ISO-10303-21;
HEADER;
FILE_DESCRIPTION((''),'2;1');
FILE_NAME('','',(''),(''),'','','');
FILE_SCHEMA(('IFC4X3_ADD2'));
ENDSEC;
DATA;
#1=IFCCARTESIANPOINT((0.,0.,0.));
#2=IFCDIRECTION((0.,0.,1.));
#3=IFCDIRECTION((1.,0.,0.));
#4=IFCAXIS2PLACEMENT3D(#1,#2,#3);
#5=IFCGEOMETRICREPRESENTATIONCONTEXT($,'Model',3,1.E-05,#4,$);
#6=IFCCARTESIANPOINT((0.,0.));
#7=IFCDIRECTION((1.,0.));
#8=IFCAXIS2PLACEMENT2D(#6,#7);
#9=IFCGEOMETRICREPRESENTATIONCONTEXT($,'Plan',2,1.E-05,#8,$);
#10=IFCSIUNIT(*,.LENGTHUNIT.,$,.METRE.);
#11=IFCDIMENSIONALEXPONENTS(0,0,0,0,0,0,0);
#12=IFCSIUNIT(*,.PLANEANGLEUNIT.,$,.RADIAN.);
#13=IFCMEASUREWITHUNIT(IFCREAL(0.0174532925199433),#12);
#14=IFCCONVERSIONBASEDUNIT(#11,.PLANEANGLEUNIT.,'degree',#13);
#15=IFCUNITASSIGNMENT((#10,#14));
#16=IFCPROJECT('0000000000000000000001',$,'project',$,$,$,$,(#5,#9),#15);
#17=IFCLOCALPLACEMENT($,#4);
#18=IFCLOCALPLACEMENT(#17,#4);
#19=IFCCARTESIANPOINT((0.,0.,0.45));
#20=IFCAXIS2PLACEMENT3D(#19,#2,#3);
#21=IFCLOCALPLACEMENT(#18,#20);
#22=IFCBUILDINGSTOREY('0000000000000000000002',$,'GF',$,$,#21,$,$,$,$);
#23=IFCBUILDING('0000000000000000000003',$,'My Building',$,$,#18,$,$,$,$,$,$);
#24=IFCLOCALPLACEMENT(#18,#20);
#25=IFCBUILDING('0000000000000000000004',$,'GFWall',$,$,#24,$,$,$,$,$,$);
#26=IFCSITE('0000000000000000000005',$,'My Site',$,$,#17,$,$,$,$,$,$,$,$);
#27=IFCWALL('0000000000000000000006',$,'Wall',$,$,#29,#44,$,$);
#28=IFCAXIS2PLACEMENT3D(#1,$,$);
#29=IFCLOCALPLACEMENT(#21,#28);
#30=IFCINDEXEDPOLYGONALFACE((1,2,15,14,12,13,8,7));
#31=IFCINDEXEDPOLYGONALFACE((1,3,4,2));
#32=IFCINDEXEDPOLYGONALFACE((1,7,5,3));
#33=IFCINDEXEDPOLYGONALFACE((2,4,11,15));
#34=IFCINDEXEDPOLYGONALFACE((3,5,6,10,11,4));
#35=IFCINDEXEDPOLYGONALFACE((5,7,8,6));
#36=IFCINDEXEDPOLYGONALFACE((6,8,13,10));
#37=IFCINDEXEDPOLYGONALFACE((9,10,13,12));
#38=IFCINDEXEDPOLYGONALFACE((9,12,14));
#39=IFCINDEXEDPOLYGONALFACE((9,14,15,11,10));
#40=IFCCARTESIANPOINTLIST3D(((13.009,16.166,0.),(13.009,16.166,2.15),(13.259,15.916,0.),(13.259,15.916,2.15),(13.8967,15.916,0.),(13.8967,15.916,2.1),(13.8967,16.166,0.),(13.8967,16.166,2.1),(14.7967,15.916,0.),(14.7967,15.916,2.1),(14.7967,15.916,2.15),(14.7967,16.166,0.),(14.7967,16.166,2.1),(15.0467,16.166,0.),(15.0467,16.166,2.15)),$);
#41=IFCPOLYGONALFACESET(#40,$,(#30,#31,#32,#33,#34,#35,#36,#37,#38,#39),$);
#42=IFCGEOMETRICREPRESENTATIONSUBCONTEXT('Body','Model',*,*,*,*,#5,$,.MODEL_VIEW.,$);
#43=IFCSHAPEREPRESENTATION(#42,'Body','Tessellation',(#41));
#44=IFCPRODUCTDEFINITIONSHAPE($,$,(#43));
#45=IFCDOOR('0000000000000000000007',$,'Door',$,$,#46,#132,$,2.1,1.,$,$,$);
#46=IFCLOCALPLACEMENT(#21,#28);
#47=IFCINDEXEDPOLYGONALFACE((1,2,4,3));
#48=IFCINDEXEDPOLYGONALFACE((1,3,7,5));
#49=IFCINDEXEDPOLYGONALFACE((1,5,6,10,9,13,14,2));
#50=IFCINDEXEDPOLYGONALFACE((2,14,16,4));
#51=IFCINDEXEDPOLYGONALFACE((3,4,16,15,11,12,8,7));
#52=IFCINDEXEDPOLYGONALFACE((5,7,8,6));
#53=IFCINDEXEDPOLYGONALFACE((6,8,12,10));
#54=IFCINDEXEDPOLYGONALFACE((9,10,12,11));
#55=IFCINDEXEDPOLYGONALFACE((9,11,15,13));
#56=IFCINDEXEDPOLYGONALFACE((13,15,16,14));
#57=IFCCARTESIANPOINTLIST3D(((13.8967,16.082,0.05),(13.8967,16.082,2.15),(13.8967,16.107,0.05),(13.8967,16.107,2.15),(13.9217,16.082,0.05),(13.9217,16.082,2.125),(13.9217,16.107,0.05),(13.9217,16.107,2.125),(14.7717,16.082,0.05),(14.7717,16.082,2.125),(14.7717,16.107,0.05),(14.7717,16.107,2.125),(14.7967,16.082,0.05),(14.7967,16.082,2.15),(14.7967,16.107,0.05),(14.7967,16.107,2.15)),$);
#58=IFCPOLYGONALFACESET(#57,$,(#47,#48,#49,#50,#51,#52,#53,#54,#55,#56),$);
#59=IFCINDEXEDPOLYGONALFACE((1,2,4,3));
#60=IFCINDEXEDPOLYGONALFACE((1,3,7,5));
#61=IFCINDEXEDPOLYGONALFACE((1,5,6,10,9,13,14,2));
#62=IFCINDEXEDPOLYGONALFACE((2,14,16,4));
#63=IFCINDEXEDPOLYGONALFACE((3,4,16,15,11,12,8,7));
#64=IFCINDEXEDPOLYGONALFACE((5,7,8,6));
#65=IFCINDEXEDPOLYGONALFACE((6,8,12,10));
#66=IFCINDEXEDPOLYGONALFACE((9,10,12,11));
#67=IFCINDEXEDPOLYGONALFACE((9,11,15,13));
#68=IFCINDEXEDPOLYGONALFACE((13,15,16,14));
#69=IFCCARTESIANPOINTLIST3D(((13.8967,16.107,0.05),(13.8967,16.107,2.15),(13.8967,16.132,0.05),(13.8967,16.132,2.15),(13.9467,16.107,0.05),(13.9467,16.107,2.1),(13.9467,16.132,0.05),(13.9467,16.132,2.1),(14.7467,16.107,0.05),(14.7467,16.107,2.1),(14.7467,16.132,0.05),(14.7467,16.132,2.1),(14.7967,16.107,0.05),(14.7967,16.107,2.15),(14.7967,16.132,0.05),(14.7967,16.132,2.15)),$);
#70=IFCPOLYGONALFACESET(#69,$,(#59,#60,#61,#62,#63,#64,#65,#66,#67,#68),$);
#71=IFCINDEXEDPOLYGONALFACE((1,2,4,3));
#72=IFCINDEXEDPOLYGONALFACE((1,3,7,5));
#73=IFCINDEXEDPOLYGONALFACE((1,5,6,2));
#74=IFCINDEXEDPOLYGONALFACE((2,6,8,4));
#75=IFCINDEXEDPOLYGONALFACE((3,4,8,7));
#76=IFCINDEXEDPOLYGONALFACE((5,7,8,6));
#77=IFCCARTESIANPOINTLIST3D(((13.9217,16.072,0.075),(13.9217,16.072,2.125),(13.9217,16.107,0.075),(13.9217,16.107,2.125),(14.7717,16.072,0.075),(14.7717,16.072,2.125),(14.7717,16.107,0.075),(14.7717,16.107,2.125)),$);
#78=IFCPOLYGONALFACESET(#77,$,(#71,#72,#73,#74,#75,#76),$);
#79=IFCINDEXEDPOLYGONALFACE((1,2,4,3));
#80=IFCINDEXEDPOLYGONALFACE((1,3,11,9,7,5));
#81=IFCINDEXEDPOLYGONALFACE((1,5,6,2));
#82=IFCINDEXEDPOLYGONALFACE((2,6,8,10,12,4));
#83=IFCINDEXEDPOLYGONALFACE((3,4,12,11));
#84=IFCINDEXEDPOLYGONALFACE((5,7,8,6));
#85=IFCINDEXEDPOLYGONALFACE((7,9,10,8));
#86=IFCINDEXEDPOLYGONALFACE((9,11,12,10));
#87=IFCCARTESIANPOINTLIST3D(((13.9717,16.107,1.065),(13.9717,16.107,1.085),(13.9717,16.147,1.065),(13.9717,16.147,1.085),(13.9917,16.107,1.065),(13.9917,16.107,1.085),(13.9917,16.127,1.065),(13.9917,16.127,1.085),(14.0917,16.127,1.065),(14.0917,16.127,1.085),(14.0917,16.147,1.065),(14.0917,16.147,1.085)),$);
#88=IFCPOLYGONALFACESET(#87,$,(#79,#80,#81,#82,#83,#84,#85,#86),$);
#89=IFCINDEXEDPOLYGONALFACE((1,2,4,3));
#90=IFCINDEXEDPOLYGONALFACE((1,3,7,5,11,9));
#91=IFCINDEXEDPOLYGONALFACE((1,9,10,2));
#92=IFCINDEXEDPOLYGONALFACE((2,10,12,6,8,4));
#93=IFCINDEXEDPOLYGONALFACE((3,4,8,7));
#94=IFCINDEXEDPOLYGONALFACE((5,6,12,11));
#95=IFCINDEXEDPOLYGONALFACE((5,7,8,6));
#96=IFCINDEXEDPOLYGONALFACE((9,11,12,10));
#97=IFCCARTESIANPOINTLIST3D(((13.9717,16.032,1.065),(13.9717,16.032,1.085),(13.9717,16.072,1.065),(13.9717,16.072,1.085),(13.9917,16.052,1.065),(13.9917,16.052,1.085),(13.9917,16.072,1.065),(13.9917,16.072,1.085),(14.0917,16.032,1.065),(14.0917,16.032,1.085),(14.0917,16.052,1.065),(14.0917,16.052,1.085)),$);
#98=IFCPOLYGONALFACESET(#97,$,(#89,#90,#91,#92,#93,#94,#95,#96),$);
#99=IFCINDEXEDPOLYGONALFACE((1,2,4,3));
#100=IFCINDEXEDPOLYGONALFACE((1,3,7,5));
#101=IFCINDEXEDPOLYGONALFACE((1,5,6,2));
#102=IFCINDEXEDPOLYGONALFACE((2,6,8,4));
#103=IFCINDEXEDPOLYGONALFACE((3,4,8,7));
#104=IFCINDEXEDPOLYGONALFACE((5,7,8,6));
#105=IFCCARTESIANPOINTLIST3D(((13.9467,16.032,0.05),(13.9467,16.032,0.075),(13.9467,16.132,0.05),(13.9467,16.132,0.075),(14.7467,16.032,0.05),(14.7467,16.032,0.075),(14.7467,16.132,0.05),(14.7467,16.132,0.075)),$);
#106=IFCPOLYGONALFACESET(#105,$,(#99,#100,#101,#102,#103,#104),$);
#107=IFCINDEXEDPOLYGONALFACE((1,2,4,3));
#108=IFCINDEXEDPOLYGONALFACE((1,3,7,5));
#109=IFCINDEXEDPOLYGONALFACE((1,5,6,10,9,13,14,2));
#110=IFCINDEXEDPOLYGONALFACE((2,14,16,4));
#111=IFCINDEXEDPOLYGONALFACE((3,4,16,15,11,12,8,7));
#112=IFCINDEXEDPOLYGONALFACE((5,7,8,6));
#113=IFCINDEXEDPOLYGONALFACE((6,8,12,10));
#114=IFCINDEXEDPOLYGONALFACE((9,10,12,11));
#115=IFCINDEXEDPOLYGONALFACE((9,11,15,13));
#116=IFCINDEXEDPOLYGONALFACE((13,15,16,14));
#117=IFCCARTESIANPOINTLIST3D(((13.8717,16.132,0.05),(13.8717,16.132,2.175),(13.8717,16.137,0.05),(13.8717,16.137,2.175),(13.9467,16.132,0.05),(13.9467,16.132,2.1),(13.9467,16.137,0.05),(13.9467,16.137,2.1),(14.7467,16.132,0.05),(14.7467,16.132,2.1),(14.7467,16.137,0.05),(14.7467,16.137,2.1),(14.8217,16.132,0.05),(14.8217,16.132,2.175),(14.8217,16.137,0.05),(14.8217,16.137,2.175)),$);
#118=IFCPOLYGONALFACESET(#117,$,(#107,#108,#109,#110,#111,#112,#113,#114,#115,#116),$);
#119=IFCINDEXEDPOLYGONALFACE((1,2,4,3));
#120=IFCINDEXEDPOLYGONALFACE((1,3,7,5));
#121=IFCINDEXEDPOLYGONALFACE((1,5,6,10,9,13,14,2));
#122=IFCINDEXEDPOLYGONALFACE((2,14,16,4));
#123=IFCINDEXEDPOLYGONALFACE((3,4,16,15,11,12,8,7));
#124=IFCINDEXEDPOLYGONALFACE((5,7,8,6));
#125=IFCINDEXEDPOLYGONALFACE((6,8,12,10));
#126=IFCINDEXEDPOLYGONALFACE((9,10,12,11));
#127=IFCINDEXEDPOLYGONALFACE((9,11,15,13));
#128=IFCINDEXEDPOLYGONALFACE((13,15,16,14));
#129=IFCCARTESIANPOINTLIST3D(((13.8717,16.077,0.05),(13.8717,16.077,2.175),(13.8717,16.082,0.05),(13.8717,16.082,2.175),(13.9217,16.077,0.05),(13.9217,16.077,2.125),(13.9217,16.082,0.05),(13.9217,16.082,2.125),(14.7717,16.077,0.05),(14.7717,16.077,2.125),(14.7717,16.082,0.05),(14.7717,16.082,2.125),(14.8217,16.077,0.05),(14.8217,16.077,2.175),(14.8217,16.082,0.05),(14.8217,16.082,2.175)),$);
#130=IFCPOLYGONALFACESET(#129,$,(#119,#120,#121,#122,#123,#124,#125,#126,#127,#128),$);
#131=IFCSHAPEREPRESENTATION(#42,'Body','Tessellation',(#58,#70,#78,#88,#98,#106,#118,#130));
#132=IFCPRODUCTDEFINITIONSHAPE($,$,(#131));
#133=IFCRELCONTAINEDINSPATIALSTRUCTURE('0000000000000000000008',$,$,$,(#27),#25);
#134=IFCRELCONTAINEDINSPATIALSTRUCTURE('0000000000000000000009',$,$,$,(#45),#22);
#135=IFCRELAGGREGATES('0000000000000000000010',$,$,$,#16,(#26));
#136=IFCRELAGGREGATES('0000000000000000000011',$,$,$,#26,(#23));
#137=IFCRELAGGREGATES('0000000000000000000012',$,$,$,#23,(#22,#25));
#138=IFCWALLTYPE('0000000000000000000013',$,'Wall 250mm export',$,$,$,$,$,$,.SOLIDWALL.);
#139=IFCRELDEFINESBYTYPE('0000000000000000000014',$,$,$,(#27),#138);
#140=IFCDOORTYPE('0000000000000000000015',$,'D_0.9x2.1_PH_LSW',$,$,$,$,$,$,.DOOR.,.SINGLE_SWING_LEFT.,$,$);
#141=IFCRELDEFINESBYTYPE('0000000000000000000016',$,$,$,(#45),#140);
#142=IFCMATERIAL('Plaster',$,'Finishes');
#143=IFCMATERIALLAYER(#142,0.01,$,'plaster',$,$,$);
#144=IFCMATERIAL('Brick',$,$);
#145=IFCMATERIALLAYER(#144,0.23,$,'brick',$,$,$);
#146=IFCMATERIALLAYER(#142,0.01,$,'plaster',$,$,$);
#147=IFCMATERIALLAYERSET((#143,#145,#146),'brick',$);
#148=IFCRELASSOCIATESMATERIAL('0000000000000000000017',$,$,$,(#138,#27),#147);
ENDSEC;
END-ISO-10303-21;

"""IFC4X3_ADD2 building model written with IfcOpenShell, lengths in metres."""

from ifc_helpers import new_model, entity, si_unit, converted_unit, frame, origin_with_axes, origin_2d_with_axis, place, context, subcontext, project, spatial, line, indexed_curve, outline, extrude, shape, source, transform, mapped, material, layer, layer_set, layer_usage, type_object, type_shapes, element, fill, save


model = new_model("IFC4X3_ADD2")

# Units and contexts
model_context = context("Model", 3, precision=1e-05, world=origin_with_axes())
plan_context = context("Plan", 2, precision=1e-05, world=origin_2d_with_axis())
body_context_1 = subcontext(model_context, "Body", "Model", "MODEL_VIEW")
body_context_2 = subcontext(plan_context, "Body", "Plan", "PLAN_VIEW")
ifc_project = project(units=[si_unit("LENGTHUNIT", "METRE"), converted_unit("PLANEANGLEUNIT", "degree", entity("IfcReal", 0.0174532925199433), si_unit("PLANEANGLEUNIT", "RADIAN"), dimensions=[0, 0, 0, 0, 0, 0, 0])], contexts=[model_context, plan_context])

# Site, building, storey
site_placement = place(None, origin_with_axes())
site = spatial("IfcSite", under=ifc_project, at=site_placement, Name="My Site")
building_1_placement = place(site_placement, origin_with_axes())
building_1 = spatial("IfcBuilding", under=site, at=building_1_placement, Name="My Building")
storey_placement = place(building_1_placement, frame((0.0, 0.0, 0.45), z_axis=(0.0, 0.0, 1.0), x_axis=(1.0, 0.0, 0.0)))
storey = spatial("IfcBuildingStorey", under=building_1, at=storey_placement, Name="GF")

# Shared definitions
building_2_placement = place(building_1_placement, frame((0.0, 0.0, 0.45), z_axis=(0.0, 0.0, 1.0), x_axis=(1.0, 0.0, 0.0)))
building_2 = spatial("IfcBuilding", under=building_1, at=building_2_placement, Name="GFWall")

# Wall, opening, door
ifc_material_1 = material(Name="Plaster", Category="Finishes")
ifc_layer_1 = layer(ifc_material_1, 0.01, Name="plaster")
ifc_material_2 = material(Name="Brick")
ifc_layer_2 = layer(ifc_material_2, 0.23, Name="brick")
ifc_layer_3 = layer(ifc_material_1, 0.01, Name="plaster")
ifc_layer_set_1 = layer_set([ifc_layer_1, ifc_layer_2, ifc_layer_3], Name="brick")
ifc_layer_usage_1 = layer_usage(ifc_layer_set_1, "AXIS2", "POSITIVE", 0.0)
wall_type = type_object("IfcWallType", Name="Wall 250mm export", PredefinedType="SOLIDWALL", material=ifc_layer_set_1)
wall_placement = place(building_2_placement, frame((13.259, 15.916, 0.0), z_axis=(0.0, 0.0, 1.0), x_axis=(1.0, 0.0, 0.0)))
wall = element("IfcWall", 1, at=wall_placement, inside=building_2, type_object=wall_type, material=ifc_layer_usage_1, Name="Wall", context=body_context_1, shape_type="SweptSolid", body=[
    extrude(outline(indexed_curve([(0.0, 0.0), (-0.25, 0.25), (1.7877, 0.25), (1.5377, 0.0)], segments=[line(1, 2, 3, 4, 1)])), origin_with_axes(), (0.0, 0.0, 1.0), 2.15),
])
shared_shape_1 = source(origin_with_axes(), body_context_1, "Body", "SweptSolid", [
    extrude(outline(indexed_curve([(0.0, 0.0), (0.9, 0.0), (0.9, 2.1), (0.0, 2.1)], segments=[line(1, 2, 3, 4, 1)])), frame((0.0, -0.6, 0.0), z_axis=(0.0, -1.0, 0.0), x_axis=(1.0, 0.0, 0.0)), (0.0, 0.0, -1.0), 1.2),
])
opening_placement = place(wall_placement, frame((1.5377, 0.216, 0.0), z_axis=(0.0, 0.0, 1.0), x_axis=(-1.0, 0.0, 0.0)))
opening = element("IfcOpeningElement", 2, at=opening_placement, cuts=wall, PredefinedType="OPENING", context=body_context_1, shape_type="MappedRepresentation", body=[
    mapped(shared_shape_1, transform((0.0, 0.0, 0.0), x_axis=(1.0, 0.0, 0.0), y_axis=(0.0, 1.0, 0.0), z_axis=(0.0, 0.0, 1.0), scale=1.0)),
])
door_type = type_object("IfcDoorType", Name="D_0.9x2.1_PH_LSW", OperationType="SINGLE_SWING_LEFT", PredefinedType="DOOR")
shared_shape_2 = source(origin_with_axes(), body_context_1, "Body", "SweptSolid", [
    extrude(outline(indexed_curve([(0.0, 0.0), (0.0, 2.1), (0.9, 2.1), (0.9, 0.0), (0.875, 0.0), (0.875, 2.075), (0.025, 2.075), (0.025, 0.0)], segments=[line(1, 2, 3, 4, 5, 6, 7, 8, 1)])), frame((0.0, 0.025, 0.0), z_axis=(0.0, -1.0, 0.0), x_axis=(1.0, 0.0, 0.0)), (0.0, 0.0, -1.0), 0.025),
    extrude(outline(indexed_curve([(0.0, 0.0), (0.0, 2.1), (0.9, 2.1), (0.9, 0.0), (0.85, 0.0), (0.85, 2.05), (0.05, 2.05), (0.05, 0.0)], segments=[line(1, 2, 3, 4, 5, 6, 7, 8, 1)])), frame((0.0, 0.0, 0.0), z_axis=(0.0, -1.0, 0.0), x_axis=(1.0, 0.0, 0.0)), (0.0, 0.0, -1.0), 0.025),
    extrude(outline(indexed_curve([(0.0, 0.0), (0.85, 0.0), (0.85, 0.035), (0.0, 0.035)], segments=[line(1, 2, 3, 4, 1)])), frame((0.025, 0.025, 0.025), z_axis=(0.0, 0.0, 1.0), x_axis=(1.0, 0.0, 0.0)), (0.0, 0.0, 1.0), 2.05),
    extrude(outline(indexed_curve([(0.0, 0.0), (0.0, -0.04), (-0.12, -0.04), (-0.12, -0.02), (-0.02, -0.02), (-0.02, 0.0)], segments=[line(1, 2, 3, 4, 5, 6, 1)])), frame((0.825, 0.025, 1.015), z_axis=(0.0, 0.0, 1.0), x_axis=(1.0, 0.0, 0.0)), (0.0, 0.0, 1.0), 0.02),
    extrude(outline(indexed_curve([(0.0, 0.0), (0.0, 0.04), (-0.12, 0.04), (-0.12, 0.02), (-0.02, 0.02), (-0.02, 0.0)], segments=[line(1, 2, 3, 4, 5, 6, 1)])), frame((0.825, 0.06, 1.015), z_axis=(0.0, 0.0, 1.0), x_axis=(1.0, 0.0, 0.0)), (0.0, 0.0, 1.0), 0.02),
    extrude(outline(indexed_curve([(0.0, 0.0), (0.8, 0.0), (0.8, 0.1), (0.0, 0.1)], segments=[line(1, 2, 3, 4, 1)])), frame((0.05, 0.0, 0.0), z_axis=(0.0, 0.0, 1.0), x_axis=(1.0, 0.0, 0.0)), (0.0, 0.0, 1.0), 0.025),
    extrude(outline(indexed_curve([(0.0, 0.0), (0.0, 2.125), (0.95, 2.125), (0.95, 0.0), (0.875, 0.0), (0.875, 2.05), (0.075, 2.05), (0.075, 0.0)], segments=[line(1, 2, 3, 4, 5, 6, 7, 8, 1)])), frame((-0.025, -0.005, 0.0), z_axis=(0.0, -1.0, 0.0), x_axis=(1.0, 0.0, 0.0)), (0.0, 0.0, -1.0), 0.005),
    extrude(outline(indexed_curve([(0.0, 0.0), (0.0, 2.125), (0.95, 2.125), (0.95, 0.0), (0.9, 0.0), (0.9, 2.075), (0.05, 2.075), (0.05, 0.0)], segments=[line(1, 2, 3, 4, 5, 6, 7, 8, 1)])), frame((-0.025, 0.05, 0.0), z_axis=(0.0, -1.0, 0.0), x_axis=(1.0, 0.0, 0.0)), (0.0, 0.0, -1.0), 0.005),
])
shared_shape_3 = source(origin_with_axes(), body_context_2, "Body", "Curve2D", [
    entity("IfcIndexedPolyCurve", entity("IfcCartesianPointList2D", [[0.0, 0.0], [0.0, 0.05], [0.025, 0.05], [0.025, 0.025], [0.05, 0.025], [0.05, 0.0]]), [entity("IfcLineIndex", [1, 2, 3, 4, 5, 6, 1])]),
    entity("IfcIndexedPolyCurve", entity("IfcCartesianPointList2D", [[0.9, 0.0], [0.9, 0.05], [0.875, 0.05], [0.875, 0.025], [0.85, 0.025], [0.85, 0.0]]), [entity("IfcLineIndex", [1, 2, 3, 4, 5, 6, 1])]),
    entity("IfcTrimmedCurve", entity("IfcEllipse", entity("IfcAxis2Placement2D", entity("IfcCartesianPoint", [0.06, 0.05]), entity("IfcDirection", [1.0, 0.0])), 0.815, 0.85), [entity("IfcCartesianPoint", [0.875, 0.05])], [entity("IfcCartesianPoint", [0.06, 0.9])], True, "CARTESIAN"),
    entity("IfcIndexedPolyCurve", entity("IfcCartesianPointList2D", [[0.025, 0.05], [0.06, 0.05], [0.06, 0.9], [0.025, 0.9]]), [entity("IfcLineIndex", [1, 2, 3, 4, 1])]),
])
type_shapes(door_type, [shared_shape_2, shared_shape_3])
door_placement = place(opening_placement, frame((0.0, 0.0, 0.05), z_axis=(0.0, 0.0, 1.0), x_axis=(1.0, 0.0, 0.0)))
door = element("IfcDoor", 3, at=door_placement, inside=storey, type_object=door_type, Name="Door", OverallHeight=2.1, OverallWidth=1.0, shapes=[
    shape(body_context_1, "Body", "MappedRepresentation", [mapped(shared_shape_2, transform((0.0, 0.0, 0.0), x_axis=(1.0, 0.0, 0.0), y_axis=(0.0, 1.0, 0.0), z_axis=(0.0, 0.0, 1.0), scale=1.0))]),
    shape(body_context_2, "Body", "MappedRepresentation", [mapped(shared_shape_3, transform((0.0, 0.0, 0.0), x_axis=(1.0, 0.0, 0.0), y_axis=(0.0, 1.0, 0.0), z_axis=(0.0, 0.0, 1.0), scale=1.0))]),
])
fill(opening, door)

save(model, "model.ifc")
